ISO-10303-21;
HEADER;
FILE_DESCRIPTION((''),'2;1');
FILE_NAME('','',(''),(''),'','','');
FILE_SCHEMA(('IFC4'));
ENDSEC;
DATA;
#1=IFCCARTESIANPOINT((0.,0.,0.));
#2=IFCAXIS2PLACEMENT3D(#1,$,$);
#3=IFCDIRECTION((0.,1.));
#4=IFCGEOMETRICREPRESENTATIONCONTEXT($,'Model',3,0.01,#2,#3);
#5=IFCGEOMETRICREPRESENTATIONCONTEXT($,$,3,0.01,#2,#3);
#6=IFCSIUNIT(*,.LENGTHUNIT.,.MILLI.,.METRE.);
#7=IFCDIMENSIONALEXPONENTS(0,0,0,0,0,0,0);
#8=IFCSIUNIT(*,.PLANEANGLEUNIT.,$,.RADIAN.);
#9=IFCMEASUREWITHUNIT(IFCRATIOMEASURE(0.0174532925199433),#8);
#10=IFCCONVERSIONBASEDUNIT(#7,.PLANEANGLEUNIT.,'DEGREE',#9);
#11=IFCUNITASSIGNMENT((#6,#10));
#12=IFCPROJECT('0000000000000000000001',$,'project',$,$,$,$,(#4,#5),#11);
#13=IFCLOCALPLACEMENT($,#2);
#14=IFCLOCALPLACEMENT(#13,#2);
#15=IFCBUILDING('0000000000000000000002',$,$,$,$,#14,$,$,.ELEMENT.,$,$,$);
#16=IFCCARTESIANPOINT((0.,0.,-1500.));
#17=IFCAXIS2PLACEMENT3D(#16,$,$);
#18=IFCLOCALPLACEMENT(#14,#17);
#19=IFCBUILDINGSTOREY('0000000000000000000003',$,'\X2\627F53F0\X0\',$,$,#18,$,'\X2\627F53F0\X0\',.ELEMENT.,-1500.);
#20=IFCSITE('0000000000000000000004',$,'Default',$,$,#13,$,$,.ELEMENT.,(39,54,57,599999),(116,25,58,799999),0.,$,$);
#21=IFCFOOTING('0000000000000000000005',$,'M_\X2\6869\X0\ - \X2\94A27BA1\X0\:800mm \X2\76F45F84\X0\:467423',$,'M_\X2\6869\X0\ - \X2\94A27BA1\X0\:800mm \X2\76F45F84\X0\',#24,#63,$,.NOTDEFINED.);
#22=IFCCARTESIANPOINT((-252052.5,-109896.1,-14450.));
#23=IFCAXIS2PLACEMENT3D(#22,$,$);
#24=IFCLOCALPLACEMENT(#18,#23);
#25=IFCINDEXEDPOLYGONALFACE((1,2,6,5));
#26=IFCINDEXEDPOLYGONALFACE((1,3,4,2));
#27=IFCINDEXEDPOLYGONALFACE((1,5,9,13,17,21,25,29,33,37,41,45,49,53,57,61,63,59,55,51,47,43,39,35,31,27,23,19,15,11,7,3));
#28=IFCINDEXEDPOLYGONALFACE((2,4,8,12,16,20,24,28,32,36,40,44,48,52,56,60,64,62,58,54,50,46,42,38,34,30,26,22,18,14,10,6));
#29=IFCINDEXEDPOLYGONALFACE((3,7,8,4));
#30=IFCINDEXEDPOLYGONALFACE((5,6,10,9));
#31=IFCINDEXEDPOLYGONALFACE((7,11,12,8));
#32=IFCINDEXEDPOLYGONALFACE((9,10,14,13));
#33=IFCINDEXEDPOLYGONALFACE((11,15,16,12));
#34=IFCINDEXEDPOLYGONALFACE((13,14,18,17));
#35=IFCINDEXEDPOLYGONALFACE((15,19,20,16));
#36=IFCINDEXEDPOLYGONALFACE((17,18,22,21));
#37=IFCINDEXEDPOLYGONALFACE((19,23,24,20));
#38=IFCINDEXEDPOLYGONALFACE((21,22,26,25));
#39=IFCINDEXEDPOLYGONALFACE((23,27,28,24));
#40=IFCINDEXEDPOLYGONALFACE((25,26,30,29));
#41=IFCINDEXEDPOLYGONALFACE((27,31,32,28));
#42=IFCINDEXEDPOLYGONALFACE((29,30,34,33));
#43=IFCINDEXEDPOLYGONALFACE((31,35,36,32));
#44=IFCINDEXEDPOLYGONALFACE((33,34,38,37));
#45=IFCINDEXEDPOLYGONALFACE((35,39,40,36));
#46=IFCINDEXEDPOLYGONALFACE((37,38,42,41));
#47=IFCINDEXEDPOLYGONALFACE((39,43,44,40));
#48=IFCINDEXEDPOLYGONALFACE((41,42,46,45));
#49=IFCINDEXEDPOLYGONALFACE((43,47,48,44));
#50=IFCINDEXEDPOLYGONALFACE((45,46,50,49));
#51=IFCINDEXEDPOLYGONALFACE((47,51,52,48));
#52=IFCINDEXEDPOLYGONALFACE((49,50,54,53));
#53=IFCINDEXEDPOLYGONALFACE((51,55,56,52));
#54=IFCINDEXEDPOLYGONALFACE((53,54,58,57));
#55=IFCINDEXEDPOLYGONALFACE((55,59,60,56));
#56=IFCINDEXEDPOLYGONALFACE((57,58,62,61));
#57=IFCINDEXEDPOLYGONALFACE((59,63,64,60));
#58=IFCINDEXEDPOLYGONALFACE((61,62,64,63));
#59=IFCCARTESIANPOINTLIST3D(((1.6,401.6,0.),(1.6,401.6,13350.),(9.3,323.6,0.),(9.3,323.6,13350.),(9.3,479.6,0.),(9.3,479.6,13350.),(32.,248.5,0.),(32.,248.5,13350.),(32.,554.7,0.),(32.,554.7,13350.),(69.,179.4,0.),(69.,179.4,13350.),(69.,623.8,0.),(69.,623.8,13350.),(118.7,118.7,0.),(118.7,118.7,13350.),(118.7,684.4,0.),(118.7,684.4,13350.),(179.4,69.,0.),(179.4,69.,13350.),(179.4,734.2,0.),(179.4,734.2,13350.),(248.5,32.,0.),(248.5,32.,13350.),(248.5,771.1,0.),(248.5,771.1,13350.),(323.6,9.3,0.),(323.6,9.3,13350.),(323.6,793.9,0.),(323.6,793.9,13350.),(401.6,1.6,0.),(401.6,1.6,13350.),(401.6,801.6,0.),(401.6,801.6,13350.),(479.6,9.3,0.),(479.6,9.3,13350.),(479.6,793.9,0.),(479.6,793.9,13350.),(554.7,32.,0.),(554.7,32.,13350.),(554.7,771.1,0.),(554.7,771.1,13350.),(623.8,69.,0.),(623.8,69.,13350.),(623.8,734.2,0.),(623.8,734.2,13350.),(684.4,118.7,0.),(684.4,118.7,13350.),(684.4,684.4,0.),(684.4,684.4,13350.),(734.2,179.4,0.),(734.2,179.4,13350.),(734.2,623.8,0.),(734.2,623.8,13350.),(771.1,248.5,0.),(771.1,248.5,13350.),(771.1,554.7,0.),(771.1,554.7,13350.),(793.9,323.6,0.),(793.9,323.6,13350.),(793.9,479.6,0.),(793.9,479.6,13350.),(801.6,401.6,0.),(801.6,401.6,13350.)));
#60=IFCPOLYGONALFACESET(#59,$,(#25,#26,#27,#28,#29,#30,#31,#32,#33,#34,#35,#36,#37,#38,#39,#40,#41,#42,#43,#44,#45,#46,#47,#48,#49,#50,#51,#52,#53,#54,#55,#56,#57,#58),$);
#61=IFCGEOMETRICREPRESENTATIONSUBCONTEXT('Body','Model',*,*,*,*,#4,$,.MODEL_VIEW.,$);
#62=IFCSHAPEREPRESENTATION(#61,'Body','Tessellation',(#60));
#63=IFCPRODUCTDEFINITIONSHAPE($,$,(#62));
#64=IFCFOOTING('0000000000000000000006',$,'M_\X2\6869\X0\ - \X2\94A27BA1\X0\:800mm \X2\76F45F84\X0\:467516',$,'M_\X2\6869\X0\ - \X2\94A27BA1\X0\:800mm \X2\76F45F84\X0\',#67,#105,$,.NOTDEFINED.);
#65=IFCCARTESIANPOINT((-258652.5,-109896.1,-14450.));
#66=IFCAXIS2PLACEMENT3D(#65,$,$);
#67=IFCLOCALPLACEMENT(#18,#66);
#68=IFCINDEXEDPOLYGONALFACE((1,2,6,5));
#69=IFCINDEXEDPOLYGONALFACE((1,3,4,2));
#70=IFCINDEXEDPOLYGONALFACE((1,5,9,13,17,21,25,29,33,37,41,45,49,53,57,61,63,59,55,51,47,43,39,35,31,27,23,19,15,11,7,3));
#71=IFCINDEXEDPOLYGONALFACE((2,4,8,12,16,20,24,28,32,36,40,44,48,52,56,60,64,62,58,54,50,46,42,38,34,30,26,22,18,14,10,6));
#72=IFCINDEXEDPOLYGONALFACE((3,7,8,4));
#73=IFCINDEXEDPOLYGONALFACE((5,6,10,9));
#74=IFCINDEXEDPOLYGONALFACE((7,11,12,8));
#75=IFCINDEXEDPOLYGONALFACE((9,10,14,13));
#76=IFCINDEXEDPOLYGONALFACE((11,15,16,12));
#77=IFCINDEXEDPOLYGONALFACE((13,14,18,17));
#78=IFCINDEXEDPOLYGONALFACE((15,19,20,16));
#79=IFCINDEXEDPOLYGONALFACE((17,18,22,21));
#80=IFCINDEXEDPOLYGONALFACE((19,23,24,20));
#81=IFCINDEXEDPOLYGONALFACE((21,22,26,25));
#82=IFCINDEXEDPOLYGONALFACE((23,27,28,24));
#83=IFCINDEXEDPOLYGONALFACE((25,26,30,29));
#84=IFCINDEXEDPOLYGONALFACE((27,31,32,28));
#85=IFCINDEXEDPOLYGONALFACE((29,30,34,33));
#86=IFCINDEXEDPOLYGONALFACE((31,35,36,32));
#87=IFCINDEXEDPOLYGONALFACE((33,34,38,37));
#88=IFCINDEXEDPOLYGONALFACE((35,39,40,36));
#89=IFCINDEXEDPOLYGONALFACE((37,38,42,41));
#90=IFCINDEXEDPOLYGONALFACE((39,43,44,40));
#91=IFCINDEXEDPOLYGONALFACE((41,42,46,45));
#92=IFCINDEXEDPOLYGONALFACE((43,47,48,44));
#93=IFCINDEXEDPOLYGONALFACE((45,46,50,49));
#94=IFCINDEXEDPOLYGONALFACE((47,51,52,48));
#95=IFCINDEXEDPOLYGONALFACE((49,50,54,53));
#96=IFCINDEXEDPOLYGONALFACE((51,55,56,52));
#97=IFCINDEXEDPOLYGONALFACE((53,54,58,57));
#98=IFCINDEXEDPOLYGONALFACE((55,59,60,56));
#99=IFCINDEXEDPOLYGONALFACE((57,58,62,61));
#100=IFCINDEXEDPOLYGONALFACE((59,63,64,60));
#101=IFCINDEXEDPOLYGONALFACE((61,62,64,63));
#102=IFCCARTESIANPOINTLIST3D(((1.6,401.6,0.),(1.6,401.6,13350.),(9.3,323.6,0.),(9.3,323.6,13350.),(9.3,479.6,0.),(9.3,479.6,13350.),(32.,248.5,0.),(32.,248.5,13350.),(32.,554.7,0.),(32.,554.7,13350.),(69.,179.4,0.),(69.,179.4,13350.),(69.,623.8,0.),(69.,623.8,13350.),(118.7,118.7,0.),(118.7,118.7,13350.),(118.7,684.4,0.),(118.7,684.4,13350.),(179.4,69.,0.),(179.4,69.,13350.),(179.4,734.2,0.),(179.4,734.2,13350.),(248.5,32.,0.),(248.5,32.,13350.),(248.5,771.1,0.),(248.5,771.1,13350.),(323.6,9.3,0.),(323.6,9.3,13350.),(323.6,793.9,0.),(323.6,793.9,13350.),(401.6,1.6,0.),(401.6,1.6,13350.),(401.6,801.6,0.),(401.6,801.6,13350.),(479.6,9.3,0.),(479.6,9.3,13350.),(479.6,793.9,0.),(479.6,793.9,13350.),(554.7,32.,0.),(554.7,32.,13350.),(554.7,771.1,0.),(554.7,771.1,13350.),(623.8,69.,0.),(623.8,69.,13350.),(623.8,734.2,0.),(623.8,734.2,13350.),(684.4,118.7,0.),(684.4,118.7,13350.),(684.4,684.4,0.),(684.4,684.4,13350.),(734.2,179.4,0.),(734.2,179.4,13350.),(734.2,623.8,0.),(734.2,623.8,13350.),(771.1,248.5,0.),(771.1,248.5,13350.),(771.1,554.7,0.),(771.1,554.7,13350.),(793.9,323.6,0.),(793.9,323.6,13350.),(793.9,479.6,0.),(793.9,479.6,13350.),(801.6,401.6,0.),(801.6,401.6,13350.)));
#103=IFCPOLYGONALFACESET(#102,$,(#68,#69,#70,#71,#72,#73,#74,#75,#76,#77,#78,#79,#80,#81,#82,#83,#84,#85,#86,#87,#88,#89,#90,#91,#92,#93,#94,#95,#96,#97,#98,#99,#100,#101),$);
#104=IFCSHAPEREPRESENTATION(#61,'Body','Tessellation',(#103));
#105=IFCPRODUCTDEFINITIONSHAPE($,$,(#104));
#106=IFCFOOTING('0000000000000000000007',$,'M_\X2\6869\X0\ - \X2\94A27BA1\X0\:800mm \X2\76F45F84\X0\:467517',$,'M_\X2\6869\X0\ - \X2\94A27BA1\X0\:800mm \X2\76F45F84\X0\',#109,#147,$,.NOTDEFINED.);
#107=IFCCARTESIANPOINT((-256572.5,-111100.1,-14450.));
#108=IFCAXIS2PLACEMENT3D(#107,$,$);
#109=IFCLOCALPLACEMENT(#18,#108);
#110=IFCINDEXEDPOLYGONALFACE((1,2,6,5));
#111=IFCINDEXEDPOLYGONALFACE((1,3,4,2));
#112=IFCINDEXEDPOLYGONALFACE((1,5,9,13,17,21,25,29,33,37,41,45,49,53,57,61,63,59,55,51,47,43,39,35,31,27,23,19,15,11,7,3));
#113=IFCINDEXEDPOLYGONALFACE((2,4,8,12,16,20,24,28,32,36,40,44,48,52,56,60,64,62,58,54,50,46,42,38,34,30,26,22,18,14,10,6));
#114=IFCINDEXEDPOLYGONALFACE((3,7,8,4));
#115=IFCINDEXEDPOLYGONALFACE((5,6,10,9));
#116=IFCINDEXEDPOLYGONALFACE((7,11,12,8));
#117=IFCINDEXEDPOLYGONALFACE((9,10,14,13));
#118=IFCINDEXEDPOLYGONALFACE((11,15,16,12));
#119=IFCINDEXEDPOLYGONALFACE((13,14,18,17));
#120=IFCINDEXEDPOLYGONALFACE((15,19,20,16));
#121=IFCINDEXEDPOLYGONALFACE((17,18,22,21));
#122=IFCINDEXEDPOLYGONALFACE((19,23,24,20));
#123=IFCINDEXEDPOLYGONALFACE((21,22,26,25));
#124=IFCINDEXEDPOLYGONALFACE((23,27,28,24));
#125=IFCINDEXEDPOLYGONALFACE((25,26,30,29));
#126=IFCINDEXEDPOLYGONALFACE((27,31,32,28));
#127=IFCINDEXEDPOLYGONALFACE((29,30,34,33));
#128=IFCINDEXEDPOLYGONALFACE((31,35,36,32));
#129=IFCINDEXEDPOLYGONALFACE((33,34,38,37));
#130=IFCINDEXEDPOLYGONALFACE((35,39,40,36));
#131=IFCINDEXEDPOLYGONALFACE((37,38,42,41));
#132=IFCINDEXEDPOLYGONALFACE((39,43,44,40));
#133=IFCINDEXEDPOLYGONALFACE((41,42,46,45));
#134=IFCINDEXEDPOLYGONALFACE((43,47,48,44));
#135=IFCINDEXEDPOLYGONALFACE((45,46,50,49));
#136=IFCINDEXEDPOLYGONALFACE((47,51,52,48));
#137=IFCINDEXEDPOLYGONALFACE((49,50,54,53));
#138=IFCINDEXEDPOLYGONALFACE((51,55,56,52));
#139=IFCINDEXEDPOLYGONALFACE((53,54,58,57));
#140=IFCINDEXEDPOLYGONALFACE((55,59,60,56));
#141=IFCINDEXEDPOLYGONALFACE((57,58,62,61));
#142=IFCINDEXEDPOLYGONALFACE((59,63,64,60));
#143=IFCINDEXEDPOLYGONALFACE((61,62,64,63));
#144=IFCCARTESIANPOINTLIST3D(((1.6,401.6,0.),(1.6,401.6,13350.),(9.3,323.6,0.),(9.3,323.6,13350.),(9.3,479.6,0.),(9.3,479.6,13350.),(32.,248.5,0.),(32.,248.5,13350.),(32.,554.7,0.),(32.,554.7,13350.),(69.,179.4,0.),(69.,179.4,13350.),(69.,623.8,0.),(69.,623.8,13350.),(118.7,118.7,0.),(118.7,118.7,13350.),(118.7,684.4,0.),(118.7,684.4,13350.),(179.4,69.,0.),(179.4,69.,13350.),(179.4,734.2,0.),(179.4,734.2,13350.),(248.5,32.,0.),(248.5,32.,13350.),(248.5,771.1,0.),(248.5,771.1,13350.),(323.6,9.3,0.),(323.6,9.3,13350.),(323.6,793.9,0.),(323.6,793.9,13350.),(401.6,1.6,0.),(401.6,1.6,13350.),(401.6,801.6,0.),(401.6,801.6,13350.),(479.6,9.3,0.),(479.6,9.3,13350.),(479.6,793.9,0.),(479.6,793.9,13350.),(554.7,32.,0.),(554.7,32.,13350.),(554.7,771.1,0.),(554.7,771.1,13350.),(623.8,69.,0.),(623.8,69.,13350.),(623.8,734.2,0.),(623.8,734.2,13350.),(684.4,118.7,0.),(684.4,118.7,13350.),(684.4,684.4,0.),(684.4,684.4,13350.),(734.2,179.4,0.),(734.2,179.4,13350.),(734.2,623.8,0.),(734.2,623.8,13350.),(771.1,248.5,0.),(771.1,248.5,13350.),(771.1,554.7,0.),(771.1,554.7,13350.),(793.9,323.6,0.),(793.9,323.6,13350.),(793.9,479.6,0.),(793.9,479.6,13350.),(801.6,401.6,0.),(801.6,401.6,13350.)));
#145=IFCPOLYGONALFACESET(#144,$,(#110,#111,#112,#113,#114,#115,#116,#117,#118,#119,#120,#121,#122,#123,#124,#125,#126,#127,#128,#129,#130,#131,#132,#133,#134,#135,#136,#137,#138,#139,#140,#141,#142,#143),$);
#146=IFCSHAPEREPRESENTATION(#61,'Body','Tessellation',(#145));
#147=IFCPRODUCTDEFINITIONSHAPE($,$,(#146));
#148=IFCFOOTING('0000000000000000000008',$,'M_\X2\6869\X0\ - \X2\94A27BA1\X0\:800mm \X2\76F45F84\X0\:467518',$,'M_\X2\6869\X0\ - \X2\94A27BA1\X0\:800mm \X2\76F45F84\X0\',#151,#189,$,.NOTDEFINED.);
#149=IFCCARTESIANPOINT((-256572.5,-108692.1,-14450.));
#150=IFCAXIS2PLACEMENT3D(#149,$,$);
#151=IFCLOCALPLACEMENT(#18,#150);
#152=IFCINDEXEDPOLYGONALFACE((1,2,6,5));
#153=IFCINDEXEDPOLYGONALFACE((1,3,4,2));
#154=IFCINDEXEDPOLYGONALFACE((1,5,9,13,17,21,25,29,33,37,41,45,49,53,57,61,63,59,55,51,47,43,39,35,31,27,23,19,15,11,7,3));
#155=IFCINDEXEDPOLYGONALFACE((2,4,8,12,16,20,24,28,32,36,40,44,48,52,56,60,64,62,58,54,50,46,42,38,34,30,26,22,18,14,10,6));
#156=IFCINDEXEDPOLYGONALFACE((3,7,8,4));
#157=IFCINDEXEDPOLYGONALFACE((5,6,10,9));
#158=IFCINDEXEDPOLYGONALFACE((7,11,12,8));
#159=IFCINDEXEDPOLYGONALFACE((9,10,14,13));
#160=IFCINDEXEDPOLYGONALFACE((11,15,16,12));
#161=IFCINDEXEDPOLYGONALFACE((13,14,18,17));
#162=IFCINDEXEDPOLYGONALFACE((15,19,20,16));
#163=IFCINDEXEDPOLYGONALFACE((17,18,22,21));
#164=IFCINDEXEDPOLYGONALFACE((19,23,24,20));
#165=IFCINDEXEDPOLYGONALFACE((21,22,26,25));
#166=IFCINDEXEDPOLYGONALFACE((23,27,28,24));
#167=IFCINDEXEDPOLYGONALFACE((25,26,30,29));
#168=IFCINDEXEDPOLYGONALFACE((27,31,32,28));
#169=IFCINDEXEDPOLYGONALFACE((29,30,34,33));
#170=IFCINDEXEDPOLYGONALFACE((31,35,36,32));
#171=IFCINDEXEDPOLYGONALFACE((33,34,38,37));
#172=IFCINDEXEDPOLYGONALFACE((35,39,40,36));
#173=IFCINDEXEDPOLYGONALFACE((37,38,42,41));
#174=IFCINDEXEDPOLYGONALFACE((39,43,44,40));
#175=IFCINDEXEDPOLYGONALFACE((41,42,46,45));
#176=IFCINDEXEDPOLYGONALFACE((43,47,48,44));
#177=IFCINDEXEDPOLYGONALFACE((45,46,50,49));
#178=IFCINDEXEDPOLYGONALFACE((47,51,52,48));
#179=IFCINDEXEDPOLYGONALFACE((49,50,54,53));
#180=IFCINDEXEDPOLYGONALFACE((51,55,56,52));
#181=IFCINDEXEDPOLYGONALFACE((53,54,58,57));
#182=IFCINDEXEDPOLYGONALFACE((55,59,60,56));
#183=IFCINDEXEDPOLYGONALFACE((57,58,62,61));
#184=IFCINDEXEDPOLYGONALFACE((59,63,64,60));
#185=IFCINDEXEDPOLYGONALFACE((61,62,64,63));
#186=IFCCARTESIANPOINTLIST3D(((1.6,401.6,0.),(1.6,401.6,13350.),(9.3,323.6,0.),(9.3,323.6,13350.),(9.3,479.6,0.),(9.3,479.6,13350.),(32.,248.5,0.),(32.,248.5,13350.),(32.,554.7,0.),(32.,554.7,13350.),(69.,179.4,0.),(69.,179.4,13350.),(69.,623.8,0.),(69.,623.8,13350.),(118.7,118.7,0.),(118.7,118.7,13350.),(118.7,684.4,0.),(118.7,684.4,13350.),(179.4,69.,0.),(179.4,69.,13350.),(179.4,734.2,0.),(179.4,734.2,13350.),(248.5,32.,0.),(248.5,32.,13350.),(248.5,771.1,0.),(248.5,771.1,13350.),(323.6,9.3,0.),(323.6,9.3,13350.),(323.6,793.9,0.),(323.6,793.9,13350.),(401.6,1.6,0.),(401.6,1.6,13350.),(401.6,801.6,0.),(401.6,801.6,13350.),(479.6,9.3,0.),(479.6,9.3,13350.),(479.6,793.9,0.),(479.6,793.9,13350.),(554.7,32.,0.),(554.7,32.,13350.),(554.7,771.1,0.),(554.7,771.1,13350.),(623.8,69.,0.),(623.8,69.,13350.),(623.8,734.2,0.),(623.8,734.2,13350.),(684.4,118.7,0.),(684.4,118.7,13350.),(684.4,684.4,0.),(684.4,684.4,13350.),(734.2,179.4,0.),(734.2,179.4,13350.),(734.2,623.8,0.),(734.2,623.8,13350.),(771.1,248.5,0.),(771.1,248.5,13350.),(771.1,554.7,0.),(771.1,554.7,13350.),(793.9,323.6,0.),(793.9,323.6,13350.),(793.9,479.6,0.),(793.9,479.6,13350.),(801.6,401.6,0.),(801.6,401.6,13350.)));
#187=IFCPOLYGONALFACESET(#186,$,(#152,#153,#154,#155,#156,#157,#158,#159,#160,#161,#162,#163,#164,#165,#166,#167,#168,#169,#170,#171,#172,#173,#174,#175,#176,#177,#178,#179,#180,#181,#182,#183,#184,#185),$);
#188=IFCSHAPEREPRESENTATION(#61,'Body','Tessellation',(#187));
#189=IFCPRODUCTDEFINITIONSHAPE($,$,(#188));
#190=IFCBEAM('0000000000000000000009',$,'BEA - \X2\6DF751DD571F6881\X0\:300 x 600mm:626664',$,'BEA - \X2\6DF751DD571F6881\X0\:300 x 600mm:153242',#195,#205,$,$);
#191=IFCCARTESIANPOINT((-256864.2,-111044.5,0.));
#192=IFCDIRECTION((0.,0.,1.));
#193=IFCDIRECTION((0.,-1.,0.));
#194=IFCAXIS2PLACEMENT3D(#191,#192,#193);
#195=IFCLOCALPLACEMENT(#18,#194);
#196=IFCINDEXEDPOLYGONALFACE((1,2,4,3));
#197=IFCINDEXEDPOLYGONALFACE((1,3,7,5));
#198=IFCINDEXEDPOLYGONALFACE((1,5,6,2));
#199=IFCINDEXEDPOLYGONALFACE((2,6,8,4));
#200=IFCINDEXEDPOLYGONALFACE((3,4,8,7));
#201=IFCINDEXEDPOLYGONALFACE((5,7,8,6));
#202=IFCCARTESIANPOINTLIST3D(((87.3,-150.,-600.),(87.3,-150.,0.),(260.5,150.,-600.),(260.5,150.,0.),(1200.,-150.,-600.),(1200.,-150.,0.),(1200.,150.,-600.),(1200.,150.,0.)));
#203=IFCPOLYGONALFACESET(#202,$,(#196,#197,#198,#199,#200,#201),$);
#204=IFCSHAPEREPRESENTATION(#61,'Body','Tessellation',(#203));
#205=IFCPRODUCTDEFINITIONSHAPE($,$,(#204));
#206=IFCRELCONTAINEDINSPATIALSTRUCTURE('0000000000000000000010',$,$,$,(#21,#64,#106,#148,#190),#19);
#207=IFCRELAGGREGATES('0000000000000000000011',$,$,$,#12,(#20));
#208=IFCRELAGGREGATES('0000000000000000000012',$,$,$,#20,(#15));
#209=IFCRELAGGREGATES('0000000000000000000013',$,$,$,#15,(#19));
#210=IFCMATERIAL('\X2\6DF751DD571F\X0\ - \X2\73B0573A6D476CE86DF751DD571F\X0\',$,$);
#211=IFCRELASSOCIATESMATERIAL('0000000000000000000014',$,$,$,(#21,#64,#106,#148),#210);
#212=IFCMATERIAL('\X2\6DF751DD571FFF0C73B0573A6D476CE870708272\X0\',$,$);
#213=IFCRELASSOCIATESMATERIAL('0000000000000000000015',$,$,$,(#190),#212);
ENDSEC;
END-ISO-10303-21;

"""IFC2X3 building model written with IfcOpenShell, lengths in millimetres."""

from ifc_helpers import new_model, entity, si_unit, converted_unit, direction, frame, frame_2d, origin, origin_2d_with_axis, place, context, subcontext, project, spatial, rectangle, circle, extrude, clip, halfspace, material, element, save


model = new_model("IFC2X3")

# Units and contexts
model_context = context("Model", 3, precision=0.01, world=origin(), true_north=direction((0.0, 1.0)))
context_of_model = context(None, 3, precision=0.01, world=origin(), true_north=direction((0.0, 1.0)))
body_context = subcontext(model_context, "Body", "Model", "MODEL_VIEW")
ifc_project = project(units=[si_unit("LENGTHUNIT", "METRE", prefix="MILLI"), converted_unit("PLANEANGLEUNIT", "DEGREE", entity("IfcRatioMeasure", 0.0174532925199433), si_unit("PLANEANGLEUNIT", "RADIAN"), dimensions=[0, 0, 0, 0, 0, 0, 0])], contexts=[model_context, context_of_model])

# Site, building, storey
site_placement = place(None, origin())
site = spatial("IfcSite", under=ifc_project, at=site_placement, Name="Default", CompositionType="ELEMENT", RefLatitude=(39, 54, 57, 599999), RefLongitude=(116, 25, 58, 799999), RefElevation=0.0)
building_placement = place(site_placement, origin())
building = spatial("IfcBuilding", under=site, at=building_placement, CompositionType="ELEMENT")
storey_placement = place(building_placement, frame((0.0, 0.0, -1500.0)))
storey = spatial("IfcBuildingStorey", under=building, at=storey_placement, Name="承台", LongName="承台", CompositionType="ELEMENT", Elevation=-1500.0)

# Footings
ifc_material_1 = material(Name="混凝土 - 现场浇注混凝土")
footing_1_placement = place(storey_placement, frame((-252052.5, -109896.1, -14450.0)))
element("IfcFooting", 1, at=footing_1_placement, inside=storey, material=ifc_material_1, Name="M_桩 - 钢管:800mm 直径:467423", ObjectType="M_桩 - 钢管:800mm 直径", PredefinedType="NOTDEFINED", context=body_context, shape_type="SweptSolid", body=[
    extrude(circle(Radius=400.0, at=origin_2d_with_axis()), frame((401.6, 401.6, 0.0), z_axis=(0.0, 0.0, 1.0), x_axis=(0.0, 1.0, 0.0)), (0.0, 0.0, 1.0), 13350.0),
])
for number, where, name in (
    (2, (-258652.5, -109896.1, -14450.0), "M_桩 - 钢管:800mm 直径:467516"),
    (3, (-256572.5, -111100.1, -14450.0), "M_桩 - 钢管:800mm 直径:467517"),
    (4, (-256572.5, -108692.1, -14450.0), "M_桩 - 钢管:800mm 直径:467518"),
):
    element("IfcFooting", number, at=place(storey_placement, frame(where)), inside=storey, material=ifc_material_1, Name=name, ObjectType="M_桩 - 钢管:800mm 直径", PredefinedType="NOTDEFINED", context=body_context, shape_type="SweptSolid", body=[
        extrude(circle(Radius=400.0, at=origin_2d_with_axis()), frame((401.6, 401.6, 0.0), z_axis=(0.0, 0.0, 1.0), x_axis=(0.0, 1.0, 0.0)), (0.0, 0.0, 1.0), 13350.0),
    ])

# Shared definitions
ifc_material_2 = material(Name="混凝土，现场浇注灰色")

# Beam
beam_1_placement = place(storey_placement, frame((-256864.2, -111044.5, 0.0), z_axis=(0.0, 0.0, 1.0), x_axis=(0.0, -1.0, 0.0)))
element("IfcBeam", 5, at=beam_1_placement, inside=storey, material=ifc_material_2, Name="BEA - 混凝土梁:300 x 600mm:626664", ObjectType="BEA - 混凝土梁:300 x 600mm:153242", context=body_context, shape_type="Clipping", body=[
    clip(extrude(rectangle(XDim=600.0, YDim=300.0, at=frame_2d((0.0, 0.0), x_axis=(1.0, 0.0))), frame((87.3, 0.0, -300.0), z_axis=(1.0, 0.0, 0.0), x_axis=(0.0, 0.0, -1.0)), (0.0, 0.0, 1.0), 1112.7), halfspace(frame((-1088.0, -2186.7, 0.0), z_axis=(-0.866125, 0.499827, 0.0), x_axis=(0.499827, 0.866125, 0.0)), False)),
])

save(model, "model.ifc")
